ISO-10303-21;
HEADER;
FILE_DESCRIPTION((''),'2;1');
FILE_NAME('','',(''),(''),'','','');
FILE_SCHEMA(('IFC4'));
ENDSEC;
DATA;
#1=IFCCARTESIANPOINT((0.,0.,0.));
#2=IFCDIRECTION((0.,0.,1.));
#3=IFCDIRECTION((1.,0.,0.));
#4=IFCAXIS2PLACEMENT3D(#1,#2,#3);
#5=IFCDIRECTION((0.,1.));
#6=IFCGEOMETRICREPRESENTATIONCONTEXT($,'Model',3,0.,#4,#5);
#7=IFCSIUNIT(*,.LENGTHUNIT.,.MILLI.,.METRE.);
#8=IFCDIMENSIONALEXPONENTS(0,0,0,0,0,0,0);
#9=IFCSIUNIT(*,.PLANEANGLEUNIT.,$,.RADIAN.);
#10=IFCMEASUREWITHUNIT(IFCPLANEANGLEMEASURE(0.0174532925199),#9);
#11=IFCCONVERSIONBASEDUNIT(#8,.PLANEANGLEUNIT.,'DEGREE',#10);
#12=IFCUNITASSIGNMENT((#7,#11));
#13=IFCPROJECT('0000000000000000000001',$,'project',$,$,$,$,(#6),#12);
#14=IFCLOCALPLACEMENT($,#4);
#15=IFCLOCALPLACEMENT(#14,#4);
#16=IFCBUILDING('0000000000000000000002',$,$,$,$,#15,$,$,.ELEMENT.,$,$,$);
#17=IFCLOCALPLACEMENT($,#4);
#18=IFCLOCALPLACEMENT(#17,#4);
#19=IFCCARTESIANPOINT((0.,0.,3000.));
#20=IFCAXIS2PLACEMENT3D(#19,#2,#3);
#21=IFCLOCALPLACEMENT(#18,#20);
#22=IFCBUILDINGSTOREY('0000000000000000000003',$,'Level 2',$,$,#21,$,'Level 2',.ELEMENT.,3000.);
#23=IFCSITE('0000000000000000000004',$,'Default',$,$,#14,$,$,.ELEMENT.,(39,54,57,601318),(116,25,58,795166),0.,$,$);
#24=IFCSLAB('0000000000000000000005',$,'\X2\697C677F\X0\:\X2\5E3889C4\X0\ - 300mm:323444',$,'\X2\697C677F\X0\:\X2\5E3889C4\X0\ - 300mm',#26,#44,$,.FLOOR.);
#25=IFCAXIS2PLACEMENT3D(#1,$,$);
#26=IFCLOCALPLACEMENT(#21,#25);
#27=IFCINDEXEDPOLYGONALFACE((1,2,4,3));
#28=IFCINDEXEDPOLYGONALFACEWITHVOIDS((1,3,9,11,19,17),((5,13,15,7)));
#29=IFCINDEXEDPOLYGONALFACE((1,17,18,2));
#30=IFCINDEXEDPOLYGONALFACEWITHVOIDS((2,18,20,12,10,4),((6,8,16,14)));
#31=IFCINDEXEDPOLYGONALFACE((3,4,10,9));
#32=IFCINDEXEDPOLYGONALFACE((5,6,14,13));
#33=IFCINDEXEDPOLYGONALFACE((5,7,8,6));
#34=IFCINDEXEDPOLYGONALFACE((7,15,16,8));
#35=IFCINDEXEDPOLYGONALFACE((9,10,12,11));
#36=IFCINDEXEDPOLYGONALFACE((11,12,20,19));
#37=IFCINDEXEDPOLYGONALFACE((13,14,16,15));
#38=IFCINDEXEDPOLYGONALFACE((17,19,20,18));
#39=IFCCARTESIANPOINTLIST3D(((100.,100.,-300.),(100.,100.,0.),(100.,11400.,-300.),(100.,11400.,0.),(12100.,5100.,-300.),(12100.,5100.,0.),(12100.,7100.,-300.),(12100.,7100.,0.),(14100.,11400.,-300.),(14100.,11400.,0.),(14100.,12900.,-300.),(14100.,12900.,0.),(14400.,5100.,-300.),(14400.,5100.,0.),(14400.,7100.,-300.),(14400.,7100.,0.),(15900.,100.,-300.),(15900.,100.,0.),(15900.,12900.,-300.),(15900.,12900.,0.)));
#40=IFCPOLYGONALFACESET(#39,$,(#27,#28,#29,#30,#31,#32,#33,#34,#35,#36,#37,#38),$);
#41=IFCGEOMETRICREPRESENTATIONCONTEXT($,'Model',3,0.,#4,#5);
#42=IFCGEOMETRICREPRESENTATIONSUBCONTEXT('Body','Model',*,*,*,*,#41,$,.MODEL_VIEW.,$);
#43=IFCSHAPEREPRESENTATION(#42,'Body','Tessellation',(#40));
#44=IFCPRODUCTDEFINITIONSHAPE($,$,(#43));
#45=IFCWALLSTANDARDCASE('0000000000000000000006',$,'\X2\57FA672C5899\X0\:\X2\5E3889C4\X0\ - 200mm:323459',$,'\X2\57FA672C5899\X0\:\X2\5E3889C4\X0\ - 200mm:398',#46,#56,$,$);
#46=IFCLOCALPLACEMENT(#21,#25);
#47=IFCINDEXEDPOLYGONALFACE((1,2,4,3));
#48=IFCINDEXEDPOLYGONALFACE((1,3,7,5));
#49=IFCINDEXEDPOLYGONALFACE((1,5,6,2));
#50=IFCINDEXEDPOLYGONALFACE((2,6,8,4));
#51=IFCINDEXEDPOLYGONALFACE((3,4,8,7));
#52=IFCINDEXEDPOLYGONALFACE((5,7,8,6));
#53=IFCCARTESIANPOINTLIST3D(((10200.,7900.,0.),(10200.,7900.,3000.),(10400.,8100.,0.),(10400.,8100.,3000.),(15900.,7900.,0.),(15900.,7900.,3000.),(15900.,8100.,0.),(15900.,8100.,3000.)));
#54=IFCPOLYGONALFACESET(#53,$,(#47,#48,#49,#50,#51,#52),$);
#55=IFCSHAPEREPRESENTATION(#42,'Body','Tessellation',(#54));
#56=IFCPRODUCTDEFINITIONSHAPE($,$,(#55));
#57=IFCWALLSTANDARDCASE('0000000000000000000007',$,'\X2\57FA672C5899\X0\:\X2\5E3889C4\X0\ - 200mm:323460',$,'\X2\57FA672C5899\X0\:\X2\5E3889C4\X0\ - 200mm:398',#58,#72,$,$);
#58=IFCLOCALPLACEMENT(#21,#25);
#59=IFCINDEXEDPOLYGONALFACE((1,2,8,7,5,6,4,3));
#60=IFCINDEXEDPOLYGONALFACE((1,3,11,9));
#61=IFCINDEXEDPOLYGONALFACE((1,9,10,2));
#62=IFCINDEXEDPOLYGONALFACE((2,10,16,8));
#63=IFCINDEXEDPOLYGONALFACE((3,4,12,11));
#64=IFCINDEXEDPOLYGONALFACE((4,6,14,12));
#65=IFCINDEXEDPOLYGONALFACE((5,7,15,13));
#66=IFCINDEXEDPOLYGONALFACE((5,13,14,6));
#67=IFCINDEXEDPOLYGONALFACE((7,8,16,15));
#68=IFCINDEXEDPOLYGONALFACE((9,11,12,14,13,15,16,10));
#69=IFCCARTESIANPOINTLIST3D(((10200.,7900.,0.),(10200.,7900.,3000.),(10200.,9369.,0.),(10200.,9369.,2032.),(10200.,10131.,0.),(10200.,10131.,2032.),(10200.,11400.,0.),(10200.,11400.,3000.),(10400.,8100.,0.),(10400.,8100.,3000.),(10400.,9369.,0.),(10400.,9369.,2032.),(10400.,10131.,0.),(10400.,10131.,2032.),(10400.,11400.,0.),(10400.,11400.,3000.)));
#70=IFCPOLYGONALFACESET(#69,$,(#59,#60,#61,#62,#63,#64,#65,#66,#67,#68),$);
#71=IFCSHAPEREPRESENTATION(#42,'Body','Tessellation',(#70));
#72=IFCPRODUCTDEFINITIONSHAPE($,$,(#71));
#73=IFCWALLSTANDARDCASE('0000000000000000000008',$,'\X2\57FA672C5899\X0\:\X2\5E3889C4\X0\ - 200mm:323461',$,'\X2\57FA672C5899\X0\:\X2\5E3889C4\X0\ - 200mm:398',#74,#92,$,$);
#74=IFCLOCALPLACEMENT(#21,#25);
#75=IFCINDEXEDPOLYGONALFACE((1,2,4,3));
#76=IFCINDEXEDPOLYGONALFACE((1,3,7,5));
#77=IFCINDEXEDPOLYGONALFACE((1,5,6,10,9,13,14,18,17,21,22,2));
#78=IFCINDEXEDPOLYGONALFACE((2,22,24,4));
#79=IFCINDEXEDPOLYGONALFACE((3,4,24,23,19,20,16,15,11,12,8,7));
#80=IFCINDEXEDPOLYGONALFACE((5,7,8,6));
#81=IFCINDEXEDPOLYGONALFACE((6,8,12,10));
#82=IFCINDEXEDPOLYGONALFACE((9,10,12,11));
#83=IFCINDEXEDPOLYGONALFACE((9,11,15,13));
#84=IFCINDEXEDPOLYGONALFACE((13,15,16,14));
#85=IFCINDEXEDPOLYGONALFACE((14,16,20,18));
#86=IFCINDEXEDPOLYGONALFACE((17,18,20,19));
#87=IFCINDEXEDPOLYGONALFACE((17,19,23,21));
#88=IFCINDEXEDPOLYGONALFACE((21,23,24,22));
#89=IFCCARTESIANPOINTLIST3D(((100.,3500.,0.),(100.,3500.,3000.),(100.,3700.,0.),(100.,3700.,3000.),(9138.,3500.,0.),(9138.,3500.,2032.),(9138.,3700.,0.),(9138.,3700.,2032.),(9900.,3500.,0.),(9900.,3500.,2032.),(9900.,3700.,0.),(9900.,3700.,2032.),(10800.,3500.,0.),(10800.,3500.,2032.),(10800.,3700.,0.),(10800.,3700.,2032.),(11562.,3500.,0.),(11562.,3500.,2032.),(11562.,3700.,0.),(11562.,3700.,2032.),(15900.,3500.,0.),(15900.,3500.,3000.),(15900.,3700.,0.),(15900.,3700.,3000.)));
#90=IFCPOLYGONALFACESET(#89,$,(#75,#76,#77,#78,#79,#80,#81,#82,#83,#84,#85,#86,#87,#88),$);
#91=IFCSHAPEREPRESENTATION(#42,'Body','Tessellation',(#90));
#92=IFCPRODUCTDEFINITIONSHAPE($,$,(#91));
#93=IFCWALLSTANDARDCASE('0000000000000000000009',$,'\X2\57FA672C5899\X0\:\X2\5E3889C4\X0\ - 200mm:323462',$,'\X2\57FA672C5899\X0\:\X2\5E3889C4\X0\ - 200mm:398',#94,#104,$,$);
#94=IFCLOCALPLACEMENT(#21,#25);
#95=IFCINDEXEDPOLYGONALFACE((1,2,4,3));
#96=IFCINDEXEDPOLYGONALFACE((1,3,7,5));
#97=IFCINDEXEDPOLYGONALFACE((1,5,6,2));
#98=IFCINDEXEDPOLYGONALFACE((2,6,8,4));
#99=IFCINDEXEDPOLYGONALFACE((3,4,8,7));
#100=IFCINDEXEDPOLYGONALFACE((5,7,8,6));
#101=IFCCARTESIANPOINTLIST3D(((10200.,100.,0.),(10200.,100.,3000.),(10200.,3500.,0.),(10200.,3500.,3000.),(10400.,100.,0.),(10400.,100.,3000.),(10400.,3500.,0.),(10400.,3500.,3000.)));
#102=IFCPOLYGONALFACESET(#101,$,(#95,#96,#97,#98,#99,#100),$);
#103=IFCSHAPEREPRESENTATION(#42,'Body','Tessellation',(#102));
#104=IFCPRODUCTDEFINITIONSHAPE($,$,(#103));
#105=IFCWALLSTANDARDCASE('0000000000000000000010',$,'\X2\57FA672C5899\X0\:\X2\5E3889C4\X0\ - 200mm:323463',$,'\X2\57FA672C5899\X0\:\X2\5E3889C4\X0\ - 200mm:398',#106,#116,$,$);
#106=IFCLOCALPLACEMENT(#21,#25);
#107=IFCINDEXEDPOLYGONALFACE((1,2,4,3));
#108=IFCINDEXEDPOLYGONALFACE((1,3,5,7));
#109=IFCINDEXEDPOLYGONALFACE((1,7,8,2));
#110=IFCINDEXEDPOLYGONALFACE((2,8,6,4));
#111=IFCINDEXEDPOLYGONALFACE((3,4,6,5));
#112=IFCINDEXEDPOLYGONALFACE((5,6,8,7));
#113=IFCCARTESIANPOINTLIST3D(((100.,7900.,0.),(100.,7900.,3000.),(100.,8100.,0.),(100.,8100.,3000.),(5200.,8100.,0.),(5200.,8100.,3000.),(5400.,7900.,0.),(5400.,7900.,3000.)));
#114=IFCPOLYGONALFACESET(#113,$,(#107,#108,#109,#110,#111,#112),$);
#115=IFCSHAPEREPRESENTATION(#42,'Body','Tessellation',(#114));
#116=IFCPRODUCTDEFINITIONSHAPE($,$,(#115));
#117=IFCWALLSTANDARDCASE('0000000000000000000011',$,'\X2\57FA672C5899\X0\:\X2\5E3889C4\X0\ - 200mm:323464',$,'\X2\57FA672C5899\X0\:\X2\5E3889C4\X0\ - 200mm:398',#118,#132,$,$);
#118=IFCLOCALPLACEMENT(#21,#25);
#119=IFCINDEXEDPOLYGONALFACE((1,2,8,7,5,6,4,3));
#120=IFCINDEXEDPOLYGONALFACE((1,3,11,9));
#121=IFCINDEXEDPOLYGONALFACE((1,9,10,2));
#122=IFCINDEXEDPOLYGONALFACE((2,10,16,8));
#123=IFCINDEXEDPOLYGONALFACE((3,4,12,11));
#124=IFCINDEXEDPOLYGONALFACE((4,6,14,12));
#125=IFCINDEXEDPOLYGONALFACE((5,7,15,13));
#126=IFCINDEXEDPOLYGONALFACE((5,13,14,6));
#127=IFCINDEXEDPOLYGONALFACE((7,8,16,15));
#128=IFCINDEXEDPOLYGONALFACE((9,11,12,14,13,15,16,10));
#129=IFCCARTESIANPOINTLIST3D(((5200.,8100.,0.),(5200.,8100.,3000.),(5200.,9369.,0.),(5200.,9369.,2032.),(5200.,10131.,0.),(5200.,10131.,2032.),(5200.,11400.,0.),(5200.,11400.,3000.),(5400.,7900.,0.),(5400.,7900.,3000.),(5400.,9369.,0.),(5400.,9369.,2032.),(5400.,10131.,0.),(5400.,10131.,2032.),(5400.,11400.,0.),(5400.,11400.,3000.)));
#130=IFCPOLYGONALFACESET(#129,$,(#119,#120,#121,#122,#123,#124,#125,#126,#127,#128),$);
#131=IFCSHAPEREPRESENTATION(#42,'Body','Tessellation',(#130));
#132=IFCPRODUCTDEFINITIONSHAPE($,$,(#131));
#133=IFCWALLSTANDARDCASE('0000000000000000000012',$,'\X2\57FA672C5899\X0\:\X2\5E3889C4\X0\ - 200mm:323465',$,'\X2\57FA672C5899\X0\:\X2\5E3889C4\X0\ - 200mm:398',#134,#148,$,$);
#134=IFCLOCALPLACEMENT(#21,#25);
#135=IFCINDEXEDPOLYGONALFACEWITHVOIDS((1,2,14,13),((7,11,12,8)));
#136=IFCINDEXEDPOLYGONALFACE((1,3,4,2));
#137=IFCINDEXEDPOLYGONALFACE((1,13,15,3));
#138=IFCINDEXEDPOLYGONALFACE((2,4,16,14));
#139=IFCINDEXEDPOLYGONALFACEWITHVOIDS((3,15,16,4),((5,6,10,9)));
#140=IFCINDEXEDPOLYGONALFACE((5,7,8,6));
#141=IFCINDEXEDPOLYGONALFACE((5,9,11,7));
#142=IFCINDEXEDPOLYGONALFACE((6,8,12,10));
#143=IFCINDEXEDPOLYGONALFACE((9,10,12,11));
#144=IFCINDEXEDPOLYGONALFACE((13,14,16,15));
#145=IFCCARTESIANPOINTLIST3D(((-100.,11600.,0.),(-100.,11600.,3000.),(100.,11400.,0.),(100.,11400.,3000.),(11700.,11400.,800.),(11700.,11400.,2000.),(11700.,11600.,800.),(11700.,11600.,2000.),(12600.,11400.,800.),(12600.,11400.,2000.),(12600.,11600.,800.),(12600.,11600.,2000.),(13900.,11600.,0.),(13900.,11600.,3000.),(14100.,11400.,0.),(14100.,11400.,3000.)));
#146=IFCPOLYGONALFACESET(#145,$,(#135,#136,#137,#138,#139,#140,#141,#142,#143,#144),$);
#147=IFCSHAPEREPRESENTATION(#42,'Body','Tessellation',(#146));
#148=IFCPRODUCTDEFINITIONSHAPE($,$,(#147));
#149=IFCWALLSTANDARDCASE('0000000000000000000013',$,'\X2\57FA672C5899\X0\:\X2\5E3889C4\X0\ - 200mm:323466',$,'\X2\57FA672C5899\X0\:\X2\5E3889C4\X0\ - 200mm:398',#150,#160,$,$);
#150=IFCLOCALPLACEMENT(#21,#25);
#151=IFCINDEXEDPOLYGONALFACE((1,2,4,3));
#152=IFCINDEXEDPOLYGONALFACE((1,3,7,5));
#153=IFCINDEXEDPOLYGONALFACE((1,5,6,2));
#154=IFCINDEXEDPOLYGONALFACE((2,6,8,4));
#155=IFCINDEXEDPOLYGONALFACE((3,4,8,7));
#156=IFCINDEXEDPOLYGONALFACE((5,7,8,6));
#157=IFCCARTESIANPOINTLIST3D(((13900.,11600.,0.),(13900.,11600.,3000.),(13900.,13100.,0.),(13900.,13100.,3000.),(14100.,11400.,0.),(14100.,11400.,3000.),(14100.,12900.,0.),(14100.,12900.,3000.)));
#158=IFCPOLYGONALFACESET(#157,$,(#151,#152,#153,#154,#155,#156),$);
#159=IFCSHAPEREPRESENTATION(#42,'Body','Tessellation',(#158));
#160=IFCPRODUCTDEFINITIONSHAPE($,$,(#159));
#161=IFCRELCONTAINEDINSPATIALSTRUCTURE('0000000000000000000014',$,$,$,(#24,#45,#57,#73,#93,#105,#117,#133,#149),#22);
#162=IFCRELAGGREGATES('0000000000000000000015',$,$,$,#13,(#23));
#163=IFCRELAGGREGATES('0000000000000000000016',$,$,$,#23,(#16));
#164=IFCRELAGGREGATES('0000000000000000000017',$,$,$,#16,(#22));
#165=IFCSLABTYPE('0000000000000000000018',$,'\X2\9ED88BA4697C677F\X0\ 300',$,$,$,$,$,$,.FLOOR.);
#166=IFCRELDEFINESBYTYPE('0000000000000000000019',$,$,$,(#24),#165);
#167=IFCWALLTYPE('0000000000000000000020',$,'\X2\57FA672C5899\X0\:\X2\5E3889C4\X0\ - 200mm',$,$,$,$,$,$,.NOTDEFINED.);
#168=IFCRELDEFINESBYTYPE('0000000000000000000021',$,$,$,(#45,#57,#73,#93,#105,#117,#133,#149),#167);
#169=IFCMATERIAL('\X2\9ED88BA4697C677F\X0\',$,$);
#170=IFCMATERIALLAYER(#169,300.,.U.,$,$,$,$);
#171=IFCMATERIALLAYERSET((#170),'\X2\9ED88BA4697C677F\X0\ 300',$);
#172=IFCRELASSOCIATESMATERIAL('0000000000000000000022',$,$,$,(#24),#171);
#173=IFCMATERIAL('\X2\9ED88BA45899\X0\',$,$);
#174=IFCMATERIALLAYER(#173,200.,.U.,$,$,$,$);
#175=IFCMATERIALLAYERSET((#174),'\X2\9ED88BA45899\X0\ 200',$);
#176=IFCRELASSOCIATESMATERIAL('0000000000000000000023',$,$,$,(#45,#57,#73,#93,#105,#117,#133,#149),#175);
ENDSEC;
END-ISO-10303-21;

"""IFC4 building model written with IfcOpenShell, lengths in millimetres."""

from ifc_helpers import new_model, entity, si_unit, converted_unit, direction, frame, origin_with_axes, place, context, subcontext, project, spatial, polyline, outline, extrude, material, layer, layer_set, layer_usage, type_object, element, save


model = new_model("IFC4")

# Units and contexts
model_context_1 = context("Model", 3, precision=0.0, world=origin_with_axes(), true_north=direction((0.0, 1.0)))
model_context_2 = context("Model", 3, precision=0.0, world=origin_with_axes(), true_north=direction((0.0, 1.0)))
body_context = subcontext(model_context_2, "Body", "Model", "MODEL_VIEW")
ifc_project = project(units=[si_unit("LENGTHUNIT", "METRE", prefix="MILLI"), converted_unit("PLANEANGLEUNIT", "DEGREE", entity("IfcPlaneAngleMeasure", 0.0174532925199), si_unit("PLANEANGLEUNIT", "RADIAN"), dimensions=[0, 0, 0, 0, 0, 0, 0])], contexts=[model_context_1])

# Site, building, storey
site_placement = place(None, origin_with_axes())
site = spatial("IfcSite", under=ifc_project, at=site_placement, Name="Default", CompositionType="ELEMENT", RefLatitude=(39, 54, 57, 601318), RefLongitude=(116, 25, 58, 795166), RefElevation=0.0)
building_placement = place(site_placement, origin_with_axes())
building = spatial("IfcBuilding", under=site, at=building_placement, CompositionType="ELEMENT")
placement_1 = place(None, origin_with_axes())
placement_2 = place(placement_1, origin_with_axes())
storey_placement = place(placement_2, frame((0.0, 0.0, 3000.0), z_axis=(0.0, 0.0, 1.0), x_axis=(1.0, 0.0, 0.0)))
storey = spatial("IfcBuildingStorey", under=building, at=storey_placement, Name="Level 2", LongName="Level 2", CompositionType="ELEMENT", Elevation=3000.0)

# Slab, opening
ifc_material_1 = material(Name="默认楼板")
ifc_layer_1 = layer(ifc_material_1, 300.0, ventilated="UNKNOWN")
ifc_layer_set_1 = layer_set([ifc_layer_1], Name="默认楼板 300")
ifc_layer_usage_1 = layer_usage(ifc_layer_set_1, "AXIS3", "NEGATIVE", 300.0)
slab_type = type_object("IfcSlabType", Name="默认楼板 300", PredefinedType="FLOOR")
slab_placement = place(storey_placement, frame((15900.0, 12900.0, -300.0), z_axis=(0.0, 0.0, 1.0), x_axis=(1.0, 0.0, 0.0)))
slab = element("IfcSlab", 1, at=slab_placement, inside=storey, type_object=slab_type, material=ifc_layer_usage_1, Name="楼板:常规 - 300mm:323444", ObjectType="楼板:常规 - 300mm", PredefinedType="FLOOR", context=body_context, shape_type="SweptSolid", body=[
    extrude(outline(polyline([(0.0, 0.0), (-1800.0, 0.0), (-1800.0, -1500.0), (-15800.0, -1500.0), (-15800.0, -12800.0), (0.0, -12800.0), (0.0, 0.0)])), origin_with_axes(), (0.0, 0.0, 1.0), 300.0),
])
opening_1_placement = place(slab_placement, origin_with_axes())
element("IfcOpeningElement", 2, at=opening_1_placement, cuts=slab, context=body_context, shape_type="SweptSolid", body=[
    extrude(outline(polyline([(-3800.0, -7800.0), (-1500.0, -7800.0), (-1500.0, -5800.0), (-3800.0, -5800.0), (-3800.0, -7800.0)])), origin_with_axes(), (0.0, 0.0, 1.0), 300.0),
])

# Wall
ifc_material_2 = material(Name="默认墙")
ifc_layer_2 = layer(ifc_material_2, 200.0, ventilated="UNKNOWN")
ifc_layer_set_2 = layer_set([ifc_layer_2], Name="默认墙 200")
ifc_layer_usage_2 = layer_usage(ifc_layer_set_2, "AXIS2", "POSITIVE", -100.0)
wall_type = type_object("IfcWallType", Name="基本墙:常规 - 200mm", PredefinedType="NOTDEFINED")
wall_1_placement = place(storey_placement, frame((10300.0, 8000.0, 0.0), z_axis=(0.0, 0.0, 1.0), x_axis=(1.0, 0.0, 0.0)))
element("IfcWallStandardCase", 3, at=wall_1_placement, inside=storey, type_object=wall_type, material=ifc_layer_usage_2, Name="基本墙:常规 - 200mm:323459", ObjectType="基本墙:常规 - 200mm:398", context=body_context, shape_type="SweptSolid", body=[
    extrude(outline(polyline([(-100.0, -100.0), (5600.0, -100.0), (5600.0, 100.0), (100.0, 100.0), (-100.0, -100.0)])), origin_with_axes(), (0.0, 0.0, 1.0), 3000.0),
])

# Wall, opening
ifc_layer_usage_3 = layer_usage(ifc_layer_set_2, "AXIS2", "POSITIVE", -100.0)
wall_2_placement = place(storey_placement, frame((10300.0, 11500.0, 0.0), z_axis=(0.0, 0.0, 1.0), x_axis=(0.0, -1.0, 0.0)))
wall_2 = element("IfcWallStandardCase", 4, at=wall_2_placement, inside=storey, type_object=wall_type, material=ifc_layer_usage_3, Name="基本墙:常规 - 200mm:323460", ObjectType="基本墙:常规 - 200mm:398", context=body_context, shape_type="SweptSolid", body=[
    extrude(outline(polyline([(100.0, -100.0), (3600.0, -100.0), (3400.0, 100.0), (100.0, 100.0), (100.0, -100.0)])), origin_with_axes(), (0.0, 0.0, 1.0), 3000.0),
])
opening_2_placement = place(wall_2_placement, frame((1750.0, 0.0, 0.0), z_axis=(0.0, 0.0, 1.0), x_axis=(1.0, 0.0, 0.0)))
element("IfcOpeningElement", 5, at=opening_2_placement, cuts=wall_2, context=body_context, shape_type="SweptSolid", body=[
    extrude(outline(polyline([(-381.0, -2032.0), (381.0, -2032.0), (381.0, 0.0), (-381.0, 0.0), (-381.0, -2032.0)])), frame((0.0, 100.0, 0.0), z_axis=(0.0, -1.0, 0.0), x_axis=(-1.0, 0.0, 0.0)), (0.0, 0.0, 1.0), 200.0),
])

# Wall, openings
ifc_layer_usage_4 = layer_usage(ifc_layer_set_2, "AXIS2", "POSITIVE", -100.0)
wall_3_placement = place(storey_placement, frame((16000.0, 3600.0, 0.0), z_axis=(0.0, 0.0, 1.0), x_axis=(-1.0, 0.0, 0.0)))
wall_3 = element("IfcWallStandardCase", 6, at=wall_3_placement, inside=storey, type_object=wall_type, material=ifc_layer_usage_4, Name="基本墙:常规 - 200mm:323461", ObjectType="基本墙:常规 - 200mm:398", context=body_context, shape_type="SweptSolid", body=[
    extrude(outline(polyline([(100.0, -100.0), (15900.0, -100.0), (15900.0, 100.0), (100.0, 100.0), (100.0, -100.0)])), origin_with_axes(), (0.0, 0.0, 1.0), 3000.0),
])
opening_3_placement = place(wall_3_placement, frame((6481.0, 0.0, 0.0), z_axis=(0.0, 0.0, 1.0), x_axis=(1.0, 0.0, 0.0)))
element("IfcOpeningElement", 7, at=opening_3_placement, cuts=wall_3, context=body_context, shape_type="SweptSolid", body=[
    extrude(outline(polyline([(-381.0, 0.0), (-381.0, -2032.0), (381.0, -2032.0), (381.0, 0.0), (-381.0, 0.0)])), frame((0.0, 100.0, 0.0), z_axis=(0.0, 1.0, 0.0), x_axis=(1.0, 0.0, 0.0)), (0.0, 0.0, -1.0), 200.0),
])
opening_4_placement = place(wall_3_placement, frame((4819.0, 0.0, 0.0), z_axis=(0.0, 0.0, 1.0), x_axis=(1.0, 0.0, 0.0)))
element("IfcOpeningElement", 8, at=opening_4_placement, cuts=wall_3, context=body_context, shape_type="SweptSolid", body=[
    extrude(outline(polyline([(-381.0, -2032.0), (381.0, -2032.0), (381.0, 0.0), (-381.0, 0.0), (-381.0, -2032.0)])), frame((0.0, 100.0, 0.0), z_axis=(0.0, -1.0, 0.0), x_axis=(-1.0, 0.0, 0.0)), (0.0, 0.0, 1.0), 200.0),
])

# Walls
ifc_layer_usage_5 = layer_usage(ifc_layer_set_2, "AXIS2", "POSITIVE", -100.0)
wall_4_placement = place(storey_placement, frame((10300.0, 3600.0, 0.0), z_axis=(0.0, 0.0, 1.0), x_axis=(0.0, -1.0, 0.0)))
element("IfcWallStandardCase", 9, at=wall_4_placement, inside=storey, type_object=wall_type, material=ifc_layer_usage_5, Name="基本墙:常规 - 200mm:323462", ObjectType="基本墙:常规 - 200mm:398", context=body_context, shape_type="SweptSolid", body=[
    extrude(outline(polyline([(100.0, -100.0), (3500.0, -100.0), (3500.0, 100.0), (100.0, 100.0), (100.0, -100.0)])), origin_with_axes(), (0.0, 0.0, 1.0), 3000.0),
])
ifc_layer_usage_6 = layer_usage(ifc_layer_set_2, "AXIS2", "POSITIVE", -100.0)
wall_5_placement = place(storey_placement, frame((0.0, 8000.0, 0.0), z_axis=(0.0, 0.0, 1.0), x_axis=(1.0, 0.0, 0.0)))
element("IfcWallStandardCase", 10, at=wall_5_placement, inside=storey, type_object=wall_type, material=ifc_layer_usage_6, Name="基本墙:常规 - 200mm:323463", ObjectType="基本墙:常规 - 200mm:398", context=body_context, shape_type="SweptSolid", body=[
    extrude(outline(polyline([(100.0, -100.0), (5400.0, -100.0), (5200.0, 100.0), (100.0, 100.0), (100.0, -100.0)])), origin_with_axes(), (0.0, 0.0, 1.0), 3000.0),
])

# Walls, openings
ifc_layer_usage_7 = layer_usage(ifc_layer_set_2, "AXIS2", "POSITIVE", -100.0)
wall_6_placement = place(storey_placement, frame((5300.0, 8000.0, 0.0), z_axis=(0.0, 0.0, 1.0), x_axis=(0.0, 1.0, 0.0)))
wall_6 = element("IfcWallStandardCase", 11, at=wall_6_placement, inside=storey, type_object=wall_type, material=ifc_layer_usage_7, Name="基本墙:常规 - 200mm:323464", ObjectType="基本墙:常规 - 200mm:398", context=body_context, shape_type="SweptSolid", body=[
    extrude(outline(polyline([(-100.0, -100.0), (3400.0, -100.0), (3400.0, 100.0), (100.0, 100.0), (-100.0, -100.0)])), origin_with_axes(), (0.0, 0.0, 1.0), 3000.0),
])
opening_5_placement = place(wall_6_placement, frame((1750.0, 0.0, 0.0), z_axis=(0.0, 0.0, 1.0), x_axis=(1.0, 0.0, 0.0)))
element("IfcOpeningElement", 12, at=opening_5_placement, cuts=wall_6, context=body_context, shape_type="SweptSolid", body=[
    extrude(outline(polyline([(-381.0, -2032.0), (381.0, -2032.0), (381.0, 0.0), (-381.0, 0.0), (-381.0, -2032.0)])), frame((0.0, 100.0, 0.0), z_axis=(0.0, -1.0, 0.0), x_axis=(-1.0, 0.0, 0.0)), (0.0, 0.0, 1.0), 200.0),
])
ifc_layer_usage_8 = layer_usage(ifc_layer_set_2, "AXIS2", "POSITIVE", -100.0)
wall_7_placement = place(storey_placement, frame((0.0, 11500.0, 0.0), z_axis=(0.0, 0.0, 1.0), x_axis=(1.0, 0.0, 0.0)))
wall_7 = element("IfcWallStandardCase", 13, at=wall_7_placement, inside=storey, type_object=wall_type, material=ifc_layer_usage_8, Name="基本墙:常规 - 200mm:323465", ObjectType="基本墙:常规 - 200mm:398", context=body_context, shape_type="SweptSolid", body=[
    extrude(outline(polyline([(100.0, -100.0), (14100.0, -100.0), (13900.0, 100.0), (-100.0, 100.0), (100.0, -100.0)])), origin_with_axes(), (0.0, 0.0, 1.0), 3000.0),
])
opening_6_placement = place(wall_7_placement, frame((12150.0, 0.0, 800.0), z_axis=(0.0, 0.0, 1.0), x_axis=(1.0, 0.0, 0.0)))
element("IfcOpeningElement", 14, at=opening_6_placement, cuts=wall_7, context=body_context, shape_type="SweptSolid", body=[
    extrude(outline(polyline([(450.0, -1200.0), (450.0, 0.0), (-450.0, 0.0), (-450.0, -1200.0), (450.0, -1200.0)])), frame((0.0, 100.0, 0.0), z_axis=(0.0, -1.0, 0.0), x_axis=(-1.0, 0.0, 0.0)), (0.0, 0.0, 1.0), 200.0),
])

# Wall
ifc_layer_usage_9 = layer_usage(ifc_layer_set_2, "AXIS2", "POSITIVE", -100.0)
wall_8_placement = place(storey_placement, frame((14000.0, 11500.0, 0.0), z_axis=(0.0, 0.0, 1.0), x_axis=(0.0, 1.0, 0.0)))
element("IfcWallStandardCase", 15, at=wall_8_placement, inside=storey, type_object=wall_type, material=ifc_layer_usage_9, Name="基本墙:常规 - 200mm:323466", ObjectType="基本墙:常规 - 200mm:398", context=body_context, shape_type="SweptSolid", body=[
    extrude(outline(polyline([(-100.0, -100.0), (1400.0, -100.0), (1600.0, 100.0), (100.0, 100.0), (-100.0, -100.0)])), origin_with_axes(), (0.0, 0.0, 1.0), 3000.0),
])

save(model, "model.ifc")
